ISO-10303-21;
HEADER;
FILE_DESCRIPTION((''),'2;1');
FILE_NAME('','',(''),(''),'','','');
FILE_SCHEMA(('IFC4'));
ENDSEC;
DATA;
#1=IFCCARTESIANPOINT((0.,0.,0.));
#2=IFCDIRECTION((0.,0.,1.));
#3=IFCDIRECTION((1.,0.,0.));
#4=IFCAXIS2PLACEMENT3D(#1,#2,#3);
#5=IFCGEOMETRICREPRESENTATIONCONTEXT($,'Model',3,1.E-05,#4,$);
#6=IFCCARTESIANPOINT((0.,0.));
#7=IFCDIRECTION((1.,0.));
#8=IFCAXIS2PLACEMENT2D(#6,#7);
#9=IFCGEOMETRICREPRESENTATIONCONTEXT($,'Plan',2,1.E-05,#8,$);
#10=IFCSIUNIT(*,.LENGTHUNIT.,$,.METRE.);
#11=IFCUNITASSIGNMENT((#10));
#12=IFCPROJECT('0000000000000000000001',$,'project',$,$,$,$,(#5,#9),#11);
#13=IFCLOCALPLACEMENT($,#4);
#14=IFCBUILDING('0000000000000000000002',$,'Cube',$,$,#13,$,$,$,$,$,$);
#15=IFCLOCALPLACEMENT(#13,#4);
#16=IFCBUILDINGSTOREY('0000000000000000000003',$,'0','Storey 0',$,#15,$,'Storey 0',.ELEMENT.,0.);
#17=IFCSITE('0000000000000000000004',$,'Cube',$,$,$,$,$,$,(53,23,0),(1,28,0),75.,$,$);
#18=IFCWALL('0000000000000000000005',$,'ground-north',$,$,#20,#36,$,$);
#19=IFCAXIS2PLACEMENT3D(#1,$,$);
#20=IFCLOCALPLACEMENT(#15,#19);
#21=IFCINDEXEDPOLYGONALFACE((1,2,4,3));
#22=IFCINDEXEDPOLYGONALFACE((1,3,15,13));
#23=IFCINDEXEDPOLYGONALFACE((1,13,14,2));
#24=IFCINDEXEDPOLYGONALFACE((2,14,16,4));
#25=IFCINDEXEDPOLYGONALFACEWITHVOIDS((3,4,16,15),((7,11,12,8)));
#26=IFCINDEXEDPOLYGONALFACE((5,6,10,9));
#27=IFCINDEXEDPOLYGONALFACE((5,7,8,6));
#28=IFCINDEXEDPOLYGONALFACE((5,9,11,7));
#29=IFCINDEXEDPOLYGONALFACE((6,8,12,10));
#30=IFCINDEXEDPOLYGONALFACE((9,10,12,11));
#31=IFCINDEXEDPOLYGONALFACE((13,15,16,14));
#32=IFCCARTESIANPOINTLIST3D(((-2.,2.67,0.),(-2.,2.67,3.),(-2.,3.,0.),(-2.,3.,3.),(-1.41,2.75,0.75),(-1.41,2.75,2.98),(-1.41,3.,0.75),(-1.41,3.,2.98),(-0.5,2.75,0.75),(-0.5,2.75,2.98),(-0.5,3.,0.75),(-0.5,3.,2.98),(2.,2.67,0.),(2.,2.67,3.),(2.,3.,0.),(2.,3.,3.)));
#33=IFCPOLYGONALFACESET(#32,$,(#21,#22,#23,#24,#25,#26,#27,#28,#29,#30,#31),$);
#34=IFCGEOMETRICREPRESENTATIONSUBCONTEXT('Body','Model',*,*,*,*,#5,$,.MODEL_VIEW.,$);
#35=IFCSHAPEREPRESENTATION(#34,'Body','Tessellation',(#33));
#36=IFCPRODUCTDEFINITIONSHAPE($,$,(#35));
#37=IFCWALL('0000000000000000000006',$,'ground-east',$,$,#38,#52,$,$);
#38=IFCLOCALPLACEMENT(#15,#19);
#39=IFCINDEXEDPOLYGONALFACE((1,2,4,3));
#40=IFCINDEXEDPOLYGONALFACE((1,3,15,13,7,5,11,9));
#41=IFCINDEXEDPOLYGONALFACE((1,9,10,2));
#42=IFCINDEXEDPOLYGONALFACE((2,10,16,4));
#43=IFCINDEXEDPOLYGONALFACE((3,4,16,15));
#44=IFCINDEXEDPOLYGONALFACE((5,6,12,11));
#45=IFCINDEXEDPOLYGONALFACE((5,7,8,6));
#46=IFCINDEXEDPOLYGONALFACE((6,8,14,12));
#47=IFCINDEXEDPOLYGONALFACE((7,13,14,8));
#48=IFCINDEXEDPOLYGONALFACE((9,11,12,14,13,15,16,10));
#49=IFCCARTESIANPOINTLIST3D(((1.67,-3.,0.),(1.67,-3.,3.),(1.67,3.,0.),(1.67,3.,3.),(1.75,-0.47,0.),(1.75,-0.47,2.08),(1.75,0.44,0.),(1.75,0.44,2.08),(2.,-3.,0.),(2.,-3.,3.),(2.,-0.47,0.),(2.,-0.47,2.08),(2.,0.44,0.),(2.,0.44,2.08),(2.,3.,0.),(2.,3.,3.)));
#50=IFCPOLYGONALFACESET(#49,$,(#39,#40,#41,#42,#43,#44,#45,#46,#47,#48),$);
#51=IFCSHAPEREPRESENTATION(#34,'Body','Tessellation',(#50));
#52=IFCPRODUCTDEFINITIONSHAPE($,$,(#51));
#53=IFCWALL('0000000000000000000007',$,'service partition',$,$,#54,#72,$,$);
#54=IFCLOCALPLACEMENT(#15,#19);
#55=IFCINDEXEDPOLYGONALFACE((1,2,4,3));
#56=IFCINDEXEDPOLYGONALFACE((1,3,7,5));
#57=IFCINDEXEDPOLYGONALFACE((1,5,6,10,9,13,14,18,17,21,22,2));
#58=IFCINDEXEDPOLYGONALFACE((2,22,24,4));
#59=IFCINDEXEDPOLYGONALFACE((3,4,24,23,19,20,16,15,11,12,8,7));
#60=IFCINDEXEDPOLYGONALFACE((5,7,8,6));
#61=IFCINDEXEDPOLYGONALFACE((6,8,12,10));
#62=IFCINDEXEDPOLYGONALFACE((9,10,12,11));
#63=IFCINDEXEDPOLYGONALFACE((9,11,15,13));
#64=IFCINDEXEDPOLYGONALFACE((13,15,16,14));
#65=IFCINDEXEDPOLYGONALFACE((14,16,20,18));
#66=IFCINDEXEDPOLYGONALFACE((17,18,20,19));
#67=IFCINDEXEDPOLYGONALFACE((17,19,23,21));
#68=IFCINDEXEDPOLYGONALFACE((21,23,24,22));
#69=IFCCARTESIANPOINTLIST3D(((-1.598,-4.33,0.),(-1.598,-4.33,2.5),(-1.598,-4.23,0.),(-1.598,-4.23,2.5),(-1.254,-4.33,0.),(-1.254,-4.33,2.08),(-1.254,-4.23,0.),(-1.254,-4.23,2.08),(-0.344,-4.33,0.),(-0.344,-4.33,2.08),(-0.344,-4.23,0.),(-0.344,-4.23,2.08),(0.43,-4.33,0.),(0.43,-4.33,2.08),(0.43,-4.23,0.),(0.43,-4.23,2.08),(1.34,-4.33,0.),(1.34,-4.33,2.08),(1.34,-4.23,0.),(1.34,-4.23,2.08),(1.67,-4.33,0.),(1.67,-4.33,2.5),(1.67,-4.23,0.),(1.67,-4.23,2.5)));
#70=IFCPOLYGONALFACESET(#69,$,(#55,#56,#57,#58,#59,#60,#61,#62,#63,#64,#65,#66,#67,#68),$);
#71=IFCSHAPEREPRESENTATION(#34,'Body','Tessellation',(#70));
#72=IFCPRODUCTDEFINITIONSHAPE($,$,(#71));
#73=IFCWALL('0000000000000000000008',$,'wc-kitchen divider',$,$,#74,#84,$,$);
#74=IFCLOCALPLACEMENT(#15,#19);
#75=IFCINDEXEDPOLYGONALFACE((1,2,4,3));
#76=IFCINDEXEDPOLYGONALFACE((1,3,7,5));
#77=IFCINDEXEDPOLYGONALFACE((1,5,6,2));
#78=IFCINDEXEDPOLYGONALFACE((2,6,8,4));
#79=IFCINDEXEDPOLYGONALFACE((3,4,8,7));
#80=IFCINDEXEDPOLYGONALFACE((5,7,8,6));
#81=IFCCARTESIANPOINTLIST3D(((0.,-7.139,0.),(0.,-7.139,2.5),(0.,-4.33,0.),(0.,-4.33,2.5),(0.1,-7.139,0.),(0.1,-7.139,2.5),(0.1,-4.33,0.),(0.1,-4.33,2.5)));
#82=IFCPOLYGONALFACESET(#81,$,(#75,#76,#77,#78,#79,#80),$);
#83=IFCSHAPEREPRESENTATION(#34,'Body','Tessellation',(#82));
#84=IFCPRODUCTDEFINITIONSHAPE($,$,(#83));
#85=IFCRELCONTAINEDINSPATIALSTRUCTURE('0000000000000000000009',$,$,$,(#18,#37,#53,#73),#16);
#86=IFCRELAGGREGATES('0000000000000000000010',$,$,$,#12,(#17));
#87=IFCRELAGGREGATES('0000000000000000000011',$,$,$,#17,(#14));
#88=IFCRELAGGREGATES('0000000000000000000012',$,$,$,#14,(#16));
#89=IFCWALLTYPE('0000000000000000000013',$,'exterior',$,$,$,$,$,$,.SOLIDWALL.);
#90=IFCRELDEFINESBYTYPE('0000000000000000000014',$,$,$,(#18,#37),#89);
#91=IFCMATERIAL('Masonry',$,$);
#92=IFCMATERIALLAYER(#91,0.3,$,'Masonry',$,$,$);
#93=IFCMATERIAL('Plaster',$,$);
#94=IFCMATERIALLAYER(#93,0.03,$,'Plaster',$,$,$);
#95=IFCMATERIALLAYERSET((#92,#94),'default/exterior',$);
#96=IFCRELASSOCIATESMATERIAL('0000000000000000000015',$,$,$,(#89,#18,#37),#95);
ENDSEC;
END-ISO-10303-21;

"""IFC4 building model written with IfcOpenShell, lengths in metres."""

from ifc_helpers import new_model, si_unit, frame, origin_with_axes, origin_2d_with_axis, place, context, subcontext, project, spatial, indexed_curve, outline, extrude, material, layer, layer_set, layer_usage, type_object, element, save


model = new_model("IFC4")

# Units and contexts
model_context = context("Model", 3, precision=1e-05, world=origin_with_axes())
plan_context = context("Plan", 2, precision=1e-05, world=origin_2d_with_axis())
body_context = subcontext(model_context, "Body", "Model", "MODEL_VIEW")
ifc_project = project(units=[si_unit("LENGTHUNIT", "METRE")], contexts=[model_context, plan_context])

# Site, building, storey
site = spatial("IfcSite", under=ifc_project, Name="Cube", RefLatitude=(53, 23, 0), RefLongitude=(1, 28, 0), RefElevation=75.0)
building_placement = place(None, origin_with_axes())
building = spatial("IfcBuilding", under=site, at=building_placement, Name="Cube")
storey_placement = place(building_placement, origin_with_axes())
storey = spatial("IfcBuildingStorey", under=building, at=storey_placement, Name="0", Description="Storey 0", LongName="Storey 0", CompositionType="ELEMENT", Elevation=0.0)

# Shared definitions
ifc_material_1 = material(Name="Masonry")
ifc_layer_1 = layer(ifc_material_1, 0.3, Name="Masonry")
ifc_material_2 = material(Name="Plaster")
ifc_layer_2 = layer(ifc_material_2, 0.03, Name="Plaster")
ifc_layer_set_1 = layer_set([ifc_layer_1, ifc_layer_2], Name="default/exterior")
wall_type = type_object("IfcWallType", Name="exterior", PredefinedType="SOLIDWALL", material=ifc_layer_set_1)

# Wall, opening
ifc_layer_usage_1 = layer_usage(ifc_layer_set_1, "AXIS2", "POSITIVE", 0.0)
wall_1_placement = place(storey_placement, frame((2.0, 3.0, 0.0), z_axis=(0.0, 0.0, 1.0), x_axis=(-1.0, 0.0, 0.0)))
wall_1 = element("IfcWall", 1, at=wall_1_placement, inside=storey, type_object=wall_type, material=ifc_layer_usage_1, Name="ground-north", context=body_context, shape_type="SweptSolid", body=[
    extrude(outline(indexed_curve([(0.0, 0.0), (0.0, 0.33), (4.0, 0.33), (4.0, 0.0), (0.0, 0.0)], self_intersect=False)), origin_with_axes(), (0.0, 0.0, 1.0), 3.0),
])
opening_1_placement = place(wall_1_placement, frame((2.5, -0.25, 0.75), z_axis=(0.0, 0.0, 1.0), x_axis=(1.0, 0.0, 0.0)))
element("IfcOpeningElement", 2, at=opening_1_placement, cuts=wall_1, PredefinedType="OPENING", context=body_context, shape_type="SweptSolid", body=[
    extrude(outline(indexed_curve([(0.0, 0.0), (0.0, 0.5), (0.91, 0.5), (0.91, 0.0), (0.0, 0.0)], self_intersect=False)), origin_with_axes(), (0.0, 0.0, 1.0), 2.23),
])

# Wall, opening
ifc_layer_usage_2 = layer_usage(ifc_layer_set_1, "AXIS2", "POSITIVE", 0.0)
wall_2_placement = place(storey_placement, frame((2.0, -3.0, 0.0), z_axis=(0.0, 0.0, 1.0), x_axis=(0.0, 1.0, 0.0)))
wall_2 = element("IfcWall", 3, at=wall_2_placement, inside=storey, type_object=wall_type, material=ifc_layer_usage_2, Name="ground-east", context=body_context, shape_type="SweptSolid", body=[
    extrude(outline(indexed_curve([(0.0, 0.0), (0.0, 0.33), (6.0, 0.33), (6.0, 0.0), (0.0, 0.0)], self_intersect=False)), origin_with_axes(), (0.0, 0.0, 1.0), 3.0),
])
opening_2_placement = place(wall_2_placement, frame((2.53, -0.25, 0.0), z_axis=(0.0, 0.0, 1.0), x_axis=(1.0, 0.0, 0.0)))
element("IfcOpeningElement", 4, at=opening_2_placement, cuts=wall_2, PredefinedType="OPENING", context=body_context, shape_type="SweptSolid", body=[
    extrude(outline(indexed_curve([(0.0, 0.0), (0.0, 0.5), (0.91, 0.5), (0.91, 0.0), (0.0, 0.0)], self_intersect=False)), origin_with_axes(), (0.0, 0.0, 1.0), 2.08),
])

# Wall, openings
wall_3_placement = place(storey_placement, frame((-1.598, -4.33, 0.0), z_axis=(0.0, 0.0, 1.0), x_axis=(1.0, 0.0, 0.0)))
wall_3 = element("IfcWall", 5, at=wall_3_placement, inside=storey, Name="service partition", context=body_context, shape_type="SweptSolid", body=[
    extrude(outline(indexed_curve([(0.0, 0.0), (0.0, 0.1), (3.268, 0.1), (3.268, 0.0), (0.0, 0.0)], self_intersect=False)), origin_with_axes(), (0.0, 0.0, 1.0), 2.5),
])
opening_3_placement = place(wall_3_placement, frame((0.344, -0.05, 0.0), z_axis=(0.0, 0.0, 1.0), x_axis=(1.0, 0.0, 0.0)))
element("IfcOpeningElement", 6, at=opening_3_placement, cuts=wall_3, context=body_context, shape_type="SweptSolid", body=[
    extrude(outline(indexed_curve([(0.0, 0.0), (0.0, 0.3), (0.91, 0.3), (0.91, 0.0), (0.0, 0.0)], self_intersect=False)), origin_with_axes(), (0.0, 0.0, 1.0), 2.08),
])
opening_4_placement = place(wall_3_placement, frame((2.028, -0.05, 0.0), z_axis=(0.0, 0.0, 1.0), x_axis=(1.0, 0.0, 0.0)))
element("IfcOpeningElement", 7, at=opening_4_placement, cuts=wall_3, context=body_context, shape_type="SweptSolid", body=[
    extrude(outline(indexed_curve([(0.0, 0.0), (0.0, 0.3), (0.91, 0.3), (0.91, 0.0), (0.0, 0.0)], self_intersect=False)), origin_with_axes(), (0.0, 0.0, 1.0), 2.08),
])

# Wall
wall_4_placement = place(storey_placement, frame((0.0, -4.33, 0.0), z_axis=(0.0, 0.0, 1.0), x_axis=(0.0, -1.0, 0.0)))
element("IfcWall", 8, at=wall_4_placement, inside=storey, Name="wc-kitchen divider", context=body_context, shape_type="SweptSolid", body=[
    extrude(outline(indexed_curve([(0.0, 0.0), (0.0, 0.1), (2.809, 0.1), (2.809, 0.0), (0.0, 0.0)], self_intersect=False)), origin_with_axes(), (0.0, 0.0, 1.0), 2.5),
])

save(model, "model.ifc")
